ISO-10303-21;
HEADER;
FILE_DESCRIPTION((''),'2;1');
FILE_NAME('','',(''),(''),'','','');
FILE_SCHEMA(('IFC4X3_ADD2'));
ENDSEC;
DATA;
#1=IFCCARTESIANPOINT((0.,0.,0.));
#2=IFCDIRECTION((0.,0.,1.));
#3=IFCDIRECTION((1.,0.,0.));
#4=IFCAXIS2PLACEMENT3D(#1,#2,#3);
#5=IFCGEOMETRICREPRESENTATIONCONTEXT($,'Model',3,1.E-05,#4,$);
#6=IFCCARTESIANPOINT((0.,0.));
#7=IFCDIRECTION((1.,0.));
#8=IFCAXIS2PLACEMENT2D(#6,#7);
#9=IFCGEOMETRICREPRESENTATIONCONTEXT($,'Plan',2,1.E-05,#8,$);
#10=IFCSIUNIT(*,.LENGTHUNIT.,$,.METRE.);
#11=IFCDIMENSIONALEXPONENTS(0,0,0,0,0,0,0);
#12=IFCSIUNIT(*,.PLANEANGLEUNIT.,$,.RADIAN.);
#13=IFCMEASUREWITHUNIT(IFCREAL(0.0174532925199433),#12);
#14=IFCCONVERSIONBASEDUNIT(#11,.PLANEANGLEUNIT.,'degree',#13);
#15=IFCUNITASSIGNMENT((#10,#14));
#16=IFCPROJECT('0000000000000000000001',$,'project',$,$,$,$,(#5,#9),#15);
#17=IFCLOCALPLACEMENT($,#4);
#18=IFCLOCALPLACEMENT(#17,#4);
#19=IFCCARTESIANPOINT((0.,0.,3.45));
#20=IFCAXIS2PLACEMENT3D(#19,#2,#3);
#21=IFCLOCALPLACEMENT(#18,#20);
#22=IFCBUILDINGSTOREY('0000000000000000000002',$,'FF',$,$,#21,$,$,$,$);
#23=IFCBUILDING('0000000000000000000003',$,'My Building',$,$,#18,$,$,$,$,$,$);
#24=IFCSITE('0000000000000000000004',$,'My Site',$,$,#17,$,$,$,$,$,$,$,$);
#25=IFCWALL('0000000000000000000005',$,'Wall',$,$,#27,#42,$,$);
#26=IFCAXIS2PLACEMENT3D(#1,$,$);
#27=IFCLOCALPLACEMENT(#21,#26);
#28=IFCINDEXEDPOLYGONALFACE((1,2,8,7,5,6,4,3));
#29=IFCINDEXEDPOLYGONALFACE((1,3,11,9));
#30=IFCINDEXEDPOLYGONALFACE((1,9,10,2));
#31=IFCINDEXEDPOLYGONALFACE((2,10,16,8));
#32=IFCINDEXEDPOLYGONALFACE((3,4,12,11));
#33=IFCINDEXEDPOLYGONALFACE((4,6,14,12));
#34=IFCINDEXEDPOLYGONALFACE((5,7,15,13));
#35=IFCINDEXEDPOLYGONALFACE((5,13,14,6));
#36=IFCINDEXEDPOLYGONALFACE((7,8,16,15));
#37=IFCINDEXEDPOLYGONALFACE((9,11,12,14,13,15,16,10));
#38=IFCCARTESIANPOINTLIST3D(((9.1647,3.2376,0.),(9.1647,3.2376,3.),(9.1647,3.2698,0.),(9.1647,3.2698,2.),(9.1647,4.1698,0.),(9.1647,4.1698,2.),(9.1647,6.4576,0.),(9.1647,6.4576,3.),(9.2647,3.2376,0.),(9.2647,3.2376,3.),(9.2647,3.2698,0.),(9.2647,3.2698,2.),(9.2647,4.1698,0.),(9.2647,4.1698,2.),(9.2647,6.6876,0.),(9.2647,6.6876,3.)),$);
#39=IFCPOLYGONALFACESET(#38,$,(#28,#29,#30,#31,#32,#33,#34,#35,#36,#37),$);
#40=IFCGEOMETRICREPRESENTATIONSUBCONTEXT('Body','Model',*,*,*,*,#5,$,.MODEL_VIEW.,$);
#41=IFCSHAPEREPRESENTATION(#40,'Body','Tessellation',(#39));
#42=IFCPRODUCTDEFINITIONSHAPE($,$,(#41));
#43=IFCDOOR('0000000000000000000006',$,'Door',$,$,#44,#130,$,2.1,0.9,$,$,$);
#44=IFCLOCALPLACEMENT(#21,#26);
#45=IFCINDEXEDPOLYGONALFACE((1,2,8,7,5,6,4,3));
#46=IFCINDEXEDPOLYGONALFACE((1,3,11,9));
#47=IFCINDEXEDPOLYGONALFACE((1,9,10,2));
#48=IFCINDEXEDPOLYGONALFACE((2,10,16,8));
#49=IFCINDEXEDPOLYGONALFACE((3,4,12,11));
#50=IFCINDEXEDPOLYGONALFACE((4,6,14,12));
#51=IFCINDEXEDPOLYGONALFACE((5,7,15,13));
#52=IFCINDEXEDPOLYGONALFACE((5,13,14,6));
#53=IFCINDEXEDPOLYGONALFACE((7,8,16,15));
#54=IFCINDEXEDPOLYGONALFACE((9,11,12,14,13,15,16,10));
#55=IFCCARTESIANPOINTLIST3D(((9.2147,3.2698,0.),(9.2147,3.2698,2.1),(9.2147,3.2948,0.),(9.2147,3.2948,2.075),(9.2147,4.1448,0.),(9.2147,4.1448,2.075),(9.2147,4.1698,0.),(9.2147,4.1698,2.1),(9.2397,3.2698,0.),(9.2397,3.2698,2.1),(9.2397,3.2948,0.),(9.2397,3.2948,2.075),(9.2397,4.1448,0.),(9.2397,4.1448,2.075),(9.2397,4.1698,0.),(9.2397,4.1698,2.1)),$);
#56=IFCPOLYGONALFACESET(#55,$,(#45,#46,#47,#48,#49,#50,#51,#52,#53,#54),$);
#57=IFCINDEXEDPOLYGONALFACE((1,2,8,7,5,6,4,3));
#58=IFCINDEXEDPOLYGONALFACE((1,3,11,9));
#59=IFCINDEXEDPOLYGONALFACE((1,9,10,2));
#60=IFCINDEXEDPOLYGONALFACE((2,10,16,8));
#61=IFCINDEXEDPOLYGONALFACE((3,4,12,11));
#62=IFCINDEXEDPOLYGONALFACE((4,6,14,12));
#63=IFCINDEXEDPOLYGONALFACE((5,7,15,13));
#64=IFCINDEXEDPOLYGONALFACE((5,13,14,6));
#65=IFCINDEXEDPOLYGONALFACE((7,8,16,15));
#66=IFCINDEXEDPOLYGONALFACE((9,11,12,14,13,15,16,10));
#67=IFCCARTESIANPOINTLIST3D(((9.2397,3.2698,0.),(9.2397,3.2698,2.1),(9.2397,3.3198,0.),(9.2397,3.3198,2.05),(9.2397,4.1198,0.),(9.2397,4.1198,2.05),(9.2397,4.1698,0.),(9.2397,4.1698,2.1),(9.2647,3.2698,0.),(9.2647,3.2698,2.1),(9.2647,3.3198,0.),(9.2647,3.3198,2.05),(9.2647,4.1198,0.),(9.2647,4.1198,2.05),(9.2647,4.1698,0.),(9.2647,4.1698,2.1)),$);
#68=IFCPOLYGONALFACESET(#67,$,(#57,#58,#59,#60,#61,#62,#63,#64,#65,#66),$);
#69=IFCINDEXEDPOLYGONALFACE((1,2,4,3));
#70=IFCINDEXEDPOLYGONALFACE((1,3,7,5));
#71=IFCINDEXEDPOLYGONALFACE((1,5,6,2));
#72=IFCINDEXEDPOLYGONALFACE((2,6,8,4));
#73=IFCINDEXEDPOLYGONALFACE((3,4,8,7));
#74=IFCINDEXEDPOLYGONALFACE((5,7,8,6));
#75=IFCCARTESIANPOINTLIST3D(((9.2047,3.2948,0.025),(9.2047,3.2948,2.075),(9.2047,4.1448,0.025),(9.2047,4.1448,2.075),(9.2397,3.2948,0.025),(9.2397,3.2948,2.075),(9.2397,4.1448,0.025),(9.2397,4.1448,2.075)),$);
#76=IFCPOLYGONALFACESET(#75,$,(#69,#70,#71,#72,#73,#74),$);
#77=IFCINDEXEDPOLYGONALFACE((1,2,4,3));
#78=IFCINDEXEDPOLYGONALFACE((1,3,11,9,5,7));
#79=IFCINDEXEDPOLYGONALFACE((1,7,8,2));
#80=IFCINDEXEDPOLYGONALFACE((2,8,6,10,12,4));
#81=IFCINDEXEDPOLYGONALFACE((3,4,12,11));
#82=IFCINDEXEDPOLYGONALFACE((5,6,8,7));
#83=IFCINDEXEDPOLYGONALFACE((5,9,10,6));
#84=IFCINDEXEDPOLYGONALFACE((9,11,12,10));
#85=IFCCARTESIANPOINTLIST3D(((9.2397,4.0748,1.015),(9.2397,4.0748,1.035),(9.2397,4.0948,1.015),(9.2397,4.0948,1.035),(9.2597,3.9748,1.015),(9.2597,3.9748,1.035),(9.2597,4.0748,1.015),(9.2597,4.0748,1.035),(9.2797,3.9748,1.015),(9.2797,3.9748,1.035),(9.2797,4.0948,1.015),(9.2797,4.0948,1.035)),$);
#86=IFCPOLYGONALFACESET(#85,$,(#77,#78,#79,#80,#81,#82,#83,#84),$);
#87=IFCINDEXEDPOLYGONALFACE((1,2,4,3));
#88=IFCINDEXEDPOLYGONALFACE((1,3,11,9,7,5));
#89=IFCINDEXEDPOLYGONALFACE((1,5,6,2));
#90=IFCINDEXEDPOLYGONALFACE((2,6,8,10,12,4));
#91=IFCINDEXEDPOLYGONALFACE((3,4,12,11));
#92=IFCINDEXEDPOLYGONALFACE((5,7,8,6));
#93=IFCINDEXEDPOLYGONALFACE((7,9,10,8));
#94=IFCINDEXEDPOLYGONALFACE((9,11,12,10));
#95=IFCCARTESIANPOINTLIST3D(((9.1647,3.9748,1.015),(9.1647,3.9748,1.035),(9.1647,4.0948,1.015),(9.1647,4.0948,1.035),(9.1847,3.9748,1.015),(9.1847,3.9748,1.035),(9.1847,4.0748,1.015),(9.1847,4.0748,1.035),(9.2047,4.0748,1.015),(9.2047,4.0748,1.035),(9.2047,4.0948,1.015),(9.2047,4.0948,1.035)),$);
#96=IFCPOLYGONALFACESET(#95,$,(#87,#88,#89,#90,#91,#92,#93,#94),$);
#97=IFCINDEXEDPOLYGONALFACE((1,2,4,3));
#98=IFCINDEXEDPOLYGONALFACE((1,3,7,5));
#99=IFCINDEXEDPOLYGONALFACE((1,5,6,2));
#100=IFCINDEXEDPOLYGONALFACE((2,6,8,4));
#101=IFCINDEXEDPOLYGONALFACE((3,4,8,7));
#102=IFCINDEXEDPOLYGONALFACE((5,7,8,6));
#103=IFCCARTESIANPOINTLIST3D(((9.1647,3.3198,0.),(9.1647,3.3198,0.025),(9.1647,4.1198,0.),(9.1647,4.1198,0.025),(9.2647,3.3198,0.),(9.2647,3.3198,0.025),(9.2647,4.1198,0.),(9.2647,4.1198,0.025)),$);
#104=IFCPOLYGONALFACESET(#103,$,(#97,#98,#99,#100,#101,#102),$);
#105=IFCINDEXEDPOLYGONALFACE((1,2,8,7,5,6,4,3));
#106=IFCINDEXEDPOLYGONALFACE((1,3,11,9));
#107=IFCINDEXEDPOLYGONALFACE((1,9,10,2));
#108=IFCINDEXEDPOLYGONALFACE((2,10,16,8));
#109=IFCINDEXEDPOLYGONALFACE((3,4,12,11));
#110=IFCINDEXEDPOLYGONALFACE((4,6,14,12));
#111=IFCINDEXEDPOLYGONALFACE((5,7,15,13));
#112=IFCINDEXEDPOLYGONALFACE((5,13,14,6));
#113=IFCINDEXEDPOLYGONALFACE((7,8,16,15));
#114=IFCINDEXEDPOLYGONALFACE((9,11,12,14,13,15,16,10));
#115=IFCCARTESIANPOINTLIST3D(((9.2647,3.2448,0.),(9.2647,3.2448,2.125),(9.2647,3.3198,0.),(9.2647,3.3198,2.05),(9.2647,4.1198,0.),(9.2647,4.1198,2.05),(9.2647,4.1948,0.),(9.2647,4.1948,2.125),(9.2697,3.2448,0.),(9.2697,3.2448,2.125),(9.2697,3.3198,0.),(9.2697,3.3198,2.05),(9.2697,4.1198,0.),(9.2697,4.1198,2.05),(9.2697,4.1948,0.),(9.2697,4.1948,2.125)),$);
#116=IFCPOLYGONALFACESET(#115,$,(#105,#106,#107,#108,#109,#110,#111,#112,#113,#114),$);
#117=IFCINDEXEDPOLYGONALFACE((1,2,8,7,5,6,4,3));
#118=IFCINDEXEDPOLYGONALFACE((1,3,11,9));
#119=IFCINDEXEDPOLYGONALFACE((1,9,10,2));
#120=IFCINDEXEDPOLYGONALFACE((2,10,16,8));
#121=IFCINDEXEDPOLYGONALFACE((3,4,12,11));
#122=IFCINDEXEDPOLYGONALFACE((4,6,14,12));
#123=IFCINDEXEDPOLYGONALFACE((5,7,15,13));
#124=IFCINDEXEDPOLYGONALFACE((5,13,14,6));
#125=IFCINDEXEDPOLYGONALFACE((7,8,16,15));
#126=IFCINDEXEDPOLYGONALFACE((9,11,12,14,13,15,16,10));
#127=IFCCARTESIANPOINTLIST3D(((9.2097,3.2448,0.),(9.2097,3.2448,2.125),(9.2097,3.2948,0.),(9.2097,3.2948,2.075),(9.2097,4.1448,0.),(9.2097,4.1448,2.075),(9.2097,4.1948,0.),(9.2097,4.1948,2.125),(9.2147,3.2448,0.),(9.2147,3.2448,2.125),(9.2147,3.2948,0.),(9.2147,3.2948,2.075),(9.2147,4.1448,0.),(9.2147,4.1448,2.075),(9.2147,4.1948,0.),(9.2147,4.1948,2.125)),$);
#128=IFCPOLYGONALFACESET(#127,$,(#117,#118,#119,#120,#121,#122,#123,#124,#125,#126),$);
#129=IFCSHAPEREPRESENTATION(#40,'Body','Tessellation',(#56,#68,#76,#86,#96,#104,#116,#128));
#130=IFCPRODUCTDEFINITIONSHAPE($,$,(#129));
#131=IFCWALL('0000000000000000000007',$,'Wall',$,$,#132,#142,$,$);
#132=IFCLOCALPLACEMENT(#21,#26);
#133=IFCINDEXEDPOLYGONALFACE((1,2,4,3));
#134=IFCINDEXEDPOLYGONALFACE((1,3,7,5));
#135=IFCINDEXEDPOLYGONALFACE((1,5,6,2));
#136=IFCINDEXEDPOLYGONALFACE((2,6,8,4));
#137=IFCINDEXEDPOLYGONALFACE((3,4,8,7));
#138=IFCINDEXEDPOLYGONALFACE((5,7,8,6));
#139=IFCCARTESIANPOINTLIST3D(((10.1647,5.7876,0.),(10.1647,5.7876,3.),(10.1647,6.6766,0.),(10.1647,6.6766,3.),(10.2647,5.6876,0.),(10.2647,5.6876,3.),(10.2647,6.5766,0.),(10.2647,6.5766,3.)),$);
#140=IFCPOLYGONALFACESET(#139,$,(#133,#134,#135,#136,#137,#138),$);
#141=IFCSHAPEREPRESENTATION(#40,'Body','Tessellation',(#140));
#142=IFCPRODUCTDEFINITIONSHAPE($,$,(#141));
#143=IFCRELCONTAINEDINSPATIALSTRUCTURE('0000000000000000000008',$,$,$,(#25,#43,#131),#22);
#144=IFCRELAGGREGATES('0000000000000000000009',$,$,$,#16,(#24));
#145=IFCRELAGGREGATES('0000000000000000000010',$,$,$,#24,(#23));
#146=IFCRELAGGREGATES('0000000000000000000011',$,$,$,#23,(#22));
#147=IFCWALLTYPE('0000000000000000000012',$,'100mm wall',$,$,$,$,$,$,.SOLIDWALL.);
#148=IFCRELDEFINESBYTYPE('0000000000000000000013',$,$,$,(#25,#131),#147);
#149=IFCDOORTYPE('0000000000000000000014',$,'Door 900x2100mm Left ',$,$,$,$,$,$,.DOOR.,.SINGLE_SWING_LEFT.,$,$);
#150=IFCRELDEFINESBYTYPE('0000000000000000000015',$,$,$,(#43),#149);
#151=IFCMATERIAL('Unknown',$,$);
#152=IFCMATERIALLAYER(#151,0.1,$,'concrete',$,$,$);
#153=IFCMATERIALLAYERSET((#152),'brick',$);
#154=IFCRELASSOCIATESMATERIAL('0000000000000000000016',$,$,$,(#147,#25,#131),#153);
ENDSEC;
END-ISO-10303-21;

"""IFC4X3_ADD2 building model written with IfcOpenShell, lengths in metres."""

from ifc_helpers import new_model, entity, si_unit, converted_unit, frame, origin_with_axes, origin_2d_with_axis, place, context, subcontext, project, spatial, line, indexed_curve, outline, extrude, shape, source, transform, mapped, material, layer, layer_set, layer_usage, type_object, type_shapes, element, fill, save


model = new_model("IFC4X3_ADD2")

# Units and contexts
model_context = context("Model", 3, precision=1e-05, world=origin_with_axes())
plan_context = context("Plan", 2, precision=1e-05, world=origin_2d_with_axis())
body_context_1 = subcontext(model_context, "Body", "Model", "MODEL_VIEW")
body_context_2 = subcontext(plan_context, "Body", "Plan", "PLAN_VIEW")
ifc_project = project(units=[si_unit("LENGTHUNIT", "METRE"), converted_unit("PLANEANGLEUNIT", "degree", entity("IfcReal", 0.0174532925199433), si_unit("PLANEANGLEUNIT", "RADIAN"), dimensions=[0, 0, 0, 0, 0, 0, 0])], contexts=[model_context, plan_context])

# Site, building, storey
site_placement = place(None, origin_with_axes())
site = spatial("IfcSite", under=ifc_project, at=site_placement, Name="My Site")
building_placement = place(site_placement, origin_with_axes())
building = spatial("IfcBuilding", under=site, at=building_placement, Name="My Building")
storey_placement = place(building_placement, frame((0.0, 0.0, 3.45), z_axis=(0.0, 0.0, 1.0), x_axis=(1.0, 0.0, 0.0)))
storey = spatial("IfcBuildingStorey", under=building, at=storey_placement, Name="FF")

# Shared definitions
ifc_material = material(Name="Unknown")

# Shared definitions
ifc_layer_1 = layer(ifc_material, 0.1, Name="concrete")
ifc_layer_set_1 = layer_set([ifc_layer_1], Name="brick")
wall_type_1 = type_object("IfcWallType", Name="100mm wall", PredefinedType="SOLIDWALL", material=ifc_layer_set_1)

# Wall, opening, door
ifc_layer_usage_1 = layer_usage(ifc_layer_set_1, "AXIS2", "POSITIVE", 0.0)
wall_1_placement = place(storey_placement, frame((9.2647, 3.2376, 0.0), z_axis=(0.0, 0.0, 1.0), x_axis=(0.0, 1.0, 0.0)))
wall_1 = element("IfcWall", 1, at=wall_1_placement, inside=storey, type_object=wall_type_1, material=ifc_layer_usage_1, Name="Wall", context=body_context_1, shape_type="SweptSolid", body=[
    extrude(outline(indexed_curve([(0.0, 0.0), (0.0, 0.1), (3.22, 0.1), (3.45, 0.0)], segments=[line(1, 2, 3, 4, 1)])), origin_with_axes(), (0.0, 0.0, 1.0), 3.0),
])
shared_shape_1 = source(origin_with_axes(), body_context_1, "Body", "SweptSolid", [
    extrude(outline(indexed_curve([(0.0, 0.0), (0.9, 0.0), (0.9, 2.1), (0.0, 2.1)], segments=[line(1, 2, 3, 4, 1)])), frame((0.0, -0.6, 0.0), z_axis=(0.0, -1.0, 0.0), x_axis=(1.0, 0.0, 0.0)), (0.0, 0.0, -1.0), 1.2),
])
opening_1_placement = place(wall_1_placement, frame((0.0322, 0.0, -0.1), z_axis=(0.0, 0.0, 1.0), x_axis=(1.0, 0.0, 0.0)))
opening_1 = element("IfcOpeningElement", 2, at=opening_1_placement, cuts=wall_1, PredefinedType="OPENING", context=body_context_1, shape_type="MappedRepresentation", body=[
    mapped(shared_shape_1, transform((0.0, 0.0, 0.0), x_axis=(1.0, 0.0, 0.0), y_axis=(0.0, 1.0, 0.0), z_axis=(0.0, 0.0, 1.0), scale=1.0)),
])
door_type_1 = type_object("IfcDoorType", Name="Door 900x2100mm Left ", OperationType="SINGLE_SWING_LEFT", PredefinedType="DOOR")
shared_shape_2 = source(origin_with_axes(), body_context_1, "Body", "SweptSolid", [
    extrude(outline(indexed_curve([(0.0, 0.0), (0.0, 2.1), (0.9, 2.1), (0.9, 0.0), (0.875, 0.0), (0.875, 2.075), (0.025, 2.075), (0.025, 0.0)], segments=[line(1, 2, 3, 4, 5, 6, 7, 8, 1)])), frame((0.0, 0.025, 0.0), z_axis=(0.0, -1.0, 0.0), x_axis=(1.0, 0.0, 0.0)), (0.0, 0.0, -1.0), 0.025),
    extrude(outline(indexed_curve([(0.0, 0.0), (0.0, 2.1), (0.9, 2.1), (0.9, 0.0), (0.85, 0.0), (0.85, 2.05), (0.05, 2.05), (0.05, 0.0)], segments=[line(1, 2, 3, 4, 5, 6, 7, 8, 1)])), frame((0.0, 0.0, 0.0), z_axis=(0.0, -1.0, 0.0), x_axis=(1.0, 0.0, 0.0)), (0.0, 0.0, -1.0), 0.025),
    extrude(outline(indexed_curve([(0.0, 0.0), (0.85, 0.0), (0.85, 0.035), (0.0, 0.035)], segments=[line(1, 2, 3, 4, 1)])), frame((0.025, 0.025, 0.025), z_axis=(0.0, 0.0, 1.0), x_axis=(1.0, 0.0, 0.0)), (0.0, 0.0, 1.0), 2.05),
    extrude(outline(indexed_curve([(0.0, 0.0), (0.0, -0.04), (-0.12, -0.04), (-0.12, -0.02), (-0.02, -0.02), (-0.02, 0.0)], segments=[line(1, 2, 3, 4, 5, 6, 1)])), frame((0.825, 0.025, 1.015), z_axis=(0.0, 0.0, 1.0), x_axis=(1.0, 0.0, 0.0)), (0.0, 0.0, 1.0), 0.02),
    extrude(outline(indexed_curve([(0.0, 0.0), (0.0, 0.04), (-0.12, 0.04), (-0.12, 0.02), (-0.02, 0.02), (-0.02, 0.0)], segments=[line(1, 2, 3, 4, 5, 6, 1)])), frame((0.825, 0.06, 1.015), z_axis=(0.0, 0.0, 1.0), x_axis=(1.0, 0.0, 0.0)), (0.0, 0.0, 1.0), 0.02),
    extrude(outline(indexed_curve([(0.0, 0.0), (0.8, 0.0), (0.8, 0.1), (0.0, 0.1)], segments=[line(1, 2, 3, 4, 1)])), frame((0.05, 0.0, 0.0), z_axis=(0.0, 0.0, 1.0), x_axis=(1.0, 0.0, 0.0)), (0.0, 0.0, 1.0), 0.025),
    extrude(outline(indexed_curve([(0.0, 0.0), (0.0, 2.125), (0.95, 2.125), (0.95, 0.0), (0.875, 0.0), (0.875, 2.05), (0.075, 2.05), (0.075, 0.0)], segments=[line(1, 2, 3, 4, 5, 6, 7, 8, 1)])), frame((-0.025, -0.005, 0.0), z_axis=(0.0, -1.0, 0.0), x_axis=(1.0, 0.0, 0.0)), (0.0, 0.0, -1.0), 0.005),
    extrude(outline(indexed_curve([(0.0, 0.0), (0.0, 2.125), (0.95, 2.125), (0.95, 0.0), (0.9, 0.0), (0.9, 2.075), (0.05, 2.075), (0.05, 0.0)], segments=[line(1, 2, 3, 4, 5, 6, 7, 8, 1)])), frame((-0.025, 0.05, 0.0), z_axis=(0.0, -1.0, 0.0), x_axis=(1.0, 0.0, 0.0)), (0.0, 0.0, -1.0), 0.005),
])
shared_shape_3 = source(origin_with_axes(), body_context_2, "Body", "Curve2D", [
    entity("IfcIndexedPolyCurve", entity("IfcCartesianPointList2D", [[0.0, 0.0], [0.0, 0.05], [0.025, 0.05], [0.025, 0.025], [0.05, 0.025], [0.05, 0.0]]), [entity("IfcLineIndex", [1, 2, 3, 4, 5, 6, 1])]),
    entity("IfcIndexedPolyCurve", entity("IfcCartesianPointList2D", [[0.9, 0.0], [0.9, 0.05], [0.875, 0.05], [0.875, 0.025], [0.85, 0.025], [0.85, 0.0]]), [entity("IfcLineIndex", [1, 2, 3, 4, 5, 6, 1])]),
    entity("IfcTrimmedCurve", entity("IfcEllipse", entity("IfcAxis2Placement2D", entity("IfcCartesianPoint", [0.06, 0.05]), entity("IfcDirection", [1.0, 0.0])), 0.815, 0.85), [entity("IfcCartesianPoint", [0.875, 0.05])], [entity("IfcCartesianPoint", [0.06, 0.9])], True, "CARTESIAN"),
    entity("IfcIndexedPolyCurve", entity("IfcCartesianPointList2D", [[0.025, 0.05], [0.06, 0.05], [0.06, 0.9], [0.025, 0.9]]), [entity("IfcLineIndex", [1, 2, 3, 4, 1])]),
])
type_shapes(door_type_1, [shared_shape_2, shared_shape_3])
door_1_placement = place(opening_1_placement, frame((0.0, 0.0, 0.1), z_axis=(0.0, 0.0, 1.0), x_axis=(1.0, 0.0, 0.0)))
door_1 = element("IfcDoor", 3, at=door_1_placement, inside=storey, type_object=door_type_1, Name="Door", OverallHeight=2.1, OverallWidth=0.9, shapes=[
    shape(body_context_1, "Body", "MappedRepresentation", [mapped(shared_shape_2, transform((0.0, 0.0, 0.0), x_axis=(1.0, 0.0, 0.0), y_axis=(0.0, 1.0, 0.0), z_axis=(0.0, 0.0, 1.0), scale=1.0))]),
    shape(body_context_2, "Body", "MappedRepresentation", [mapped(shared_shape_3, transform((0.0, 0.0, 0.0), x_axis=(1.0, 0.0, 0.0), y_axis=(0.0, 1.0, 0.0), z_axis=(0.0, 0.0, 1.0), scale=1.0))]),
])
fill(opening_1, door_1)

# Wall
ifc_layer_usage_2 = layer_usage(ifc_layer_set_1, "AXIS2", "POSITIVE", 0.0)
wall_2_placement = place(storey_placement, frame((10.2647, 5.7876, 0.0), z_axis=(0.0, 0.0, 1.0), x_axis=(0.0, 1.0, 0.0)))
element("IfcWall", 4, at=wall_2_placement, inside=storey, type_object=wall_type_1, material=ifc_layer_usage_2, Name="Wall", context=body_context_1, shape_type="SweptSolid", body=[
    extrude(outline(indexed_curve([(-0.1, 0.0), (0.0, 0.1), (0.889, 0.1), (0.789, 0.0)], segments=[line(1, 2, 3, 4, 1)])), origin_with_axes(), (0.0, 0.0, 1.0), 3.0),
])

save(model, "model.ifc")
